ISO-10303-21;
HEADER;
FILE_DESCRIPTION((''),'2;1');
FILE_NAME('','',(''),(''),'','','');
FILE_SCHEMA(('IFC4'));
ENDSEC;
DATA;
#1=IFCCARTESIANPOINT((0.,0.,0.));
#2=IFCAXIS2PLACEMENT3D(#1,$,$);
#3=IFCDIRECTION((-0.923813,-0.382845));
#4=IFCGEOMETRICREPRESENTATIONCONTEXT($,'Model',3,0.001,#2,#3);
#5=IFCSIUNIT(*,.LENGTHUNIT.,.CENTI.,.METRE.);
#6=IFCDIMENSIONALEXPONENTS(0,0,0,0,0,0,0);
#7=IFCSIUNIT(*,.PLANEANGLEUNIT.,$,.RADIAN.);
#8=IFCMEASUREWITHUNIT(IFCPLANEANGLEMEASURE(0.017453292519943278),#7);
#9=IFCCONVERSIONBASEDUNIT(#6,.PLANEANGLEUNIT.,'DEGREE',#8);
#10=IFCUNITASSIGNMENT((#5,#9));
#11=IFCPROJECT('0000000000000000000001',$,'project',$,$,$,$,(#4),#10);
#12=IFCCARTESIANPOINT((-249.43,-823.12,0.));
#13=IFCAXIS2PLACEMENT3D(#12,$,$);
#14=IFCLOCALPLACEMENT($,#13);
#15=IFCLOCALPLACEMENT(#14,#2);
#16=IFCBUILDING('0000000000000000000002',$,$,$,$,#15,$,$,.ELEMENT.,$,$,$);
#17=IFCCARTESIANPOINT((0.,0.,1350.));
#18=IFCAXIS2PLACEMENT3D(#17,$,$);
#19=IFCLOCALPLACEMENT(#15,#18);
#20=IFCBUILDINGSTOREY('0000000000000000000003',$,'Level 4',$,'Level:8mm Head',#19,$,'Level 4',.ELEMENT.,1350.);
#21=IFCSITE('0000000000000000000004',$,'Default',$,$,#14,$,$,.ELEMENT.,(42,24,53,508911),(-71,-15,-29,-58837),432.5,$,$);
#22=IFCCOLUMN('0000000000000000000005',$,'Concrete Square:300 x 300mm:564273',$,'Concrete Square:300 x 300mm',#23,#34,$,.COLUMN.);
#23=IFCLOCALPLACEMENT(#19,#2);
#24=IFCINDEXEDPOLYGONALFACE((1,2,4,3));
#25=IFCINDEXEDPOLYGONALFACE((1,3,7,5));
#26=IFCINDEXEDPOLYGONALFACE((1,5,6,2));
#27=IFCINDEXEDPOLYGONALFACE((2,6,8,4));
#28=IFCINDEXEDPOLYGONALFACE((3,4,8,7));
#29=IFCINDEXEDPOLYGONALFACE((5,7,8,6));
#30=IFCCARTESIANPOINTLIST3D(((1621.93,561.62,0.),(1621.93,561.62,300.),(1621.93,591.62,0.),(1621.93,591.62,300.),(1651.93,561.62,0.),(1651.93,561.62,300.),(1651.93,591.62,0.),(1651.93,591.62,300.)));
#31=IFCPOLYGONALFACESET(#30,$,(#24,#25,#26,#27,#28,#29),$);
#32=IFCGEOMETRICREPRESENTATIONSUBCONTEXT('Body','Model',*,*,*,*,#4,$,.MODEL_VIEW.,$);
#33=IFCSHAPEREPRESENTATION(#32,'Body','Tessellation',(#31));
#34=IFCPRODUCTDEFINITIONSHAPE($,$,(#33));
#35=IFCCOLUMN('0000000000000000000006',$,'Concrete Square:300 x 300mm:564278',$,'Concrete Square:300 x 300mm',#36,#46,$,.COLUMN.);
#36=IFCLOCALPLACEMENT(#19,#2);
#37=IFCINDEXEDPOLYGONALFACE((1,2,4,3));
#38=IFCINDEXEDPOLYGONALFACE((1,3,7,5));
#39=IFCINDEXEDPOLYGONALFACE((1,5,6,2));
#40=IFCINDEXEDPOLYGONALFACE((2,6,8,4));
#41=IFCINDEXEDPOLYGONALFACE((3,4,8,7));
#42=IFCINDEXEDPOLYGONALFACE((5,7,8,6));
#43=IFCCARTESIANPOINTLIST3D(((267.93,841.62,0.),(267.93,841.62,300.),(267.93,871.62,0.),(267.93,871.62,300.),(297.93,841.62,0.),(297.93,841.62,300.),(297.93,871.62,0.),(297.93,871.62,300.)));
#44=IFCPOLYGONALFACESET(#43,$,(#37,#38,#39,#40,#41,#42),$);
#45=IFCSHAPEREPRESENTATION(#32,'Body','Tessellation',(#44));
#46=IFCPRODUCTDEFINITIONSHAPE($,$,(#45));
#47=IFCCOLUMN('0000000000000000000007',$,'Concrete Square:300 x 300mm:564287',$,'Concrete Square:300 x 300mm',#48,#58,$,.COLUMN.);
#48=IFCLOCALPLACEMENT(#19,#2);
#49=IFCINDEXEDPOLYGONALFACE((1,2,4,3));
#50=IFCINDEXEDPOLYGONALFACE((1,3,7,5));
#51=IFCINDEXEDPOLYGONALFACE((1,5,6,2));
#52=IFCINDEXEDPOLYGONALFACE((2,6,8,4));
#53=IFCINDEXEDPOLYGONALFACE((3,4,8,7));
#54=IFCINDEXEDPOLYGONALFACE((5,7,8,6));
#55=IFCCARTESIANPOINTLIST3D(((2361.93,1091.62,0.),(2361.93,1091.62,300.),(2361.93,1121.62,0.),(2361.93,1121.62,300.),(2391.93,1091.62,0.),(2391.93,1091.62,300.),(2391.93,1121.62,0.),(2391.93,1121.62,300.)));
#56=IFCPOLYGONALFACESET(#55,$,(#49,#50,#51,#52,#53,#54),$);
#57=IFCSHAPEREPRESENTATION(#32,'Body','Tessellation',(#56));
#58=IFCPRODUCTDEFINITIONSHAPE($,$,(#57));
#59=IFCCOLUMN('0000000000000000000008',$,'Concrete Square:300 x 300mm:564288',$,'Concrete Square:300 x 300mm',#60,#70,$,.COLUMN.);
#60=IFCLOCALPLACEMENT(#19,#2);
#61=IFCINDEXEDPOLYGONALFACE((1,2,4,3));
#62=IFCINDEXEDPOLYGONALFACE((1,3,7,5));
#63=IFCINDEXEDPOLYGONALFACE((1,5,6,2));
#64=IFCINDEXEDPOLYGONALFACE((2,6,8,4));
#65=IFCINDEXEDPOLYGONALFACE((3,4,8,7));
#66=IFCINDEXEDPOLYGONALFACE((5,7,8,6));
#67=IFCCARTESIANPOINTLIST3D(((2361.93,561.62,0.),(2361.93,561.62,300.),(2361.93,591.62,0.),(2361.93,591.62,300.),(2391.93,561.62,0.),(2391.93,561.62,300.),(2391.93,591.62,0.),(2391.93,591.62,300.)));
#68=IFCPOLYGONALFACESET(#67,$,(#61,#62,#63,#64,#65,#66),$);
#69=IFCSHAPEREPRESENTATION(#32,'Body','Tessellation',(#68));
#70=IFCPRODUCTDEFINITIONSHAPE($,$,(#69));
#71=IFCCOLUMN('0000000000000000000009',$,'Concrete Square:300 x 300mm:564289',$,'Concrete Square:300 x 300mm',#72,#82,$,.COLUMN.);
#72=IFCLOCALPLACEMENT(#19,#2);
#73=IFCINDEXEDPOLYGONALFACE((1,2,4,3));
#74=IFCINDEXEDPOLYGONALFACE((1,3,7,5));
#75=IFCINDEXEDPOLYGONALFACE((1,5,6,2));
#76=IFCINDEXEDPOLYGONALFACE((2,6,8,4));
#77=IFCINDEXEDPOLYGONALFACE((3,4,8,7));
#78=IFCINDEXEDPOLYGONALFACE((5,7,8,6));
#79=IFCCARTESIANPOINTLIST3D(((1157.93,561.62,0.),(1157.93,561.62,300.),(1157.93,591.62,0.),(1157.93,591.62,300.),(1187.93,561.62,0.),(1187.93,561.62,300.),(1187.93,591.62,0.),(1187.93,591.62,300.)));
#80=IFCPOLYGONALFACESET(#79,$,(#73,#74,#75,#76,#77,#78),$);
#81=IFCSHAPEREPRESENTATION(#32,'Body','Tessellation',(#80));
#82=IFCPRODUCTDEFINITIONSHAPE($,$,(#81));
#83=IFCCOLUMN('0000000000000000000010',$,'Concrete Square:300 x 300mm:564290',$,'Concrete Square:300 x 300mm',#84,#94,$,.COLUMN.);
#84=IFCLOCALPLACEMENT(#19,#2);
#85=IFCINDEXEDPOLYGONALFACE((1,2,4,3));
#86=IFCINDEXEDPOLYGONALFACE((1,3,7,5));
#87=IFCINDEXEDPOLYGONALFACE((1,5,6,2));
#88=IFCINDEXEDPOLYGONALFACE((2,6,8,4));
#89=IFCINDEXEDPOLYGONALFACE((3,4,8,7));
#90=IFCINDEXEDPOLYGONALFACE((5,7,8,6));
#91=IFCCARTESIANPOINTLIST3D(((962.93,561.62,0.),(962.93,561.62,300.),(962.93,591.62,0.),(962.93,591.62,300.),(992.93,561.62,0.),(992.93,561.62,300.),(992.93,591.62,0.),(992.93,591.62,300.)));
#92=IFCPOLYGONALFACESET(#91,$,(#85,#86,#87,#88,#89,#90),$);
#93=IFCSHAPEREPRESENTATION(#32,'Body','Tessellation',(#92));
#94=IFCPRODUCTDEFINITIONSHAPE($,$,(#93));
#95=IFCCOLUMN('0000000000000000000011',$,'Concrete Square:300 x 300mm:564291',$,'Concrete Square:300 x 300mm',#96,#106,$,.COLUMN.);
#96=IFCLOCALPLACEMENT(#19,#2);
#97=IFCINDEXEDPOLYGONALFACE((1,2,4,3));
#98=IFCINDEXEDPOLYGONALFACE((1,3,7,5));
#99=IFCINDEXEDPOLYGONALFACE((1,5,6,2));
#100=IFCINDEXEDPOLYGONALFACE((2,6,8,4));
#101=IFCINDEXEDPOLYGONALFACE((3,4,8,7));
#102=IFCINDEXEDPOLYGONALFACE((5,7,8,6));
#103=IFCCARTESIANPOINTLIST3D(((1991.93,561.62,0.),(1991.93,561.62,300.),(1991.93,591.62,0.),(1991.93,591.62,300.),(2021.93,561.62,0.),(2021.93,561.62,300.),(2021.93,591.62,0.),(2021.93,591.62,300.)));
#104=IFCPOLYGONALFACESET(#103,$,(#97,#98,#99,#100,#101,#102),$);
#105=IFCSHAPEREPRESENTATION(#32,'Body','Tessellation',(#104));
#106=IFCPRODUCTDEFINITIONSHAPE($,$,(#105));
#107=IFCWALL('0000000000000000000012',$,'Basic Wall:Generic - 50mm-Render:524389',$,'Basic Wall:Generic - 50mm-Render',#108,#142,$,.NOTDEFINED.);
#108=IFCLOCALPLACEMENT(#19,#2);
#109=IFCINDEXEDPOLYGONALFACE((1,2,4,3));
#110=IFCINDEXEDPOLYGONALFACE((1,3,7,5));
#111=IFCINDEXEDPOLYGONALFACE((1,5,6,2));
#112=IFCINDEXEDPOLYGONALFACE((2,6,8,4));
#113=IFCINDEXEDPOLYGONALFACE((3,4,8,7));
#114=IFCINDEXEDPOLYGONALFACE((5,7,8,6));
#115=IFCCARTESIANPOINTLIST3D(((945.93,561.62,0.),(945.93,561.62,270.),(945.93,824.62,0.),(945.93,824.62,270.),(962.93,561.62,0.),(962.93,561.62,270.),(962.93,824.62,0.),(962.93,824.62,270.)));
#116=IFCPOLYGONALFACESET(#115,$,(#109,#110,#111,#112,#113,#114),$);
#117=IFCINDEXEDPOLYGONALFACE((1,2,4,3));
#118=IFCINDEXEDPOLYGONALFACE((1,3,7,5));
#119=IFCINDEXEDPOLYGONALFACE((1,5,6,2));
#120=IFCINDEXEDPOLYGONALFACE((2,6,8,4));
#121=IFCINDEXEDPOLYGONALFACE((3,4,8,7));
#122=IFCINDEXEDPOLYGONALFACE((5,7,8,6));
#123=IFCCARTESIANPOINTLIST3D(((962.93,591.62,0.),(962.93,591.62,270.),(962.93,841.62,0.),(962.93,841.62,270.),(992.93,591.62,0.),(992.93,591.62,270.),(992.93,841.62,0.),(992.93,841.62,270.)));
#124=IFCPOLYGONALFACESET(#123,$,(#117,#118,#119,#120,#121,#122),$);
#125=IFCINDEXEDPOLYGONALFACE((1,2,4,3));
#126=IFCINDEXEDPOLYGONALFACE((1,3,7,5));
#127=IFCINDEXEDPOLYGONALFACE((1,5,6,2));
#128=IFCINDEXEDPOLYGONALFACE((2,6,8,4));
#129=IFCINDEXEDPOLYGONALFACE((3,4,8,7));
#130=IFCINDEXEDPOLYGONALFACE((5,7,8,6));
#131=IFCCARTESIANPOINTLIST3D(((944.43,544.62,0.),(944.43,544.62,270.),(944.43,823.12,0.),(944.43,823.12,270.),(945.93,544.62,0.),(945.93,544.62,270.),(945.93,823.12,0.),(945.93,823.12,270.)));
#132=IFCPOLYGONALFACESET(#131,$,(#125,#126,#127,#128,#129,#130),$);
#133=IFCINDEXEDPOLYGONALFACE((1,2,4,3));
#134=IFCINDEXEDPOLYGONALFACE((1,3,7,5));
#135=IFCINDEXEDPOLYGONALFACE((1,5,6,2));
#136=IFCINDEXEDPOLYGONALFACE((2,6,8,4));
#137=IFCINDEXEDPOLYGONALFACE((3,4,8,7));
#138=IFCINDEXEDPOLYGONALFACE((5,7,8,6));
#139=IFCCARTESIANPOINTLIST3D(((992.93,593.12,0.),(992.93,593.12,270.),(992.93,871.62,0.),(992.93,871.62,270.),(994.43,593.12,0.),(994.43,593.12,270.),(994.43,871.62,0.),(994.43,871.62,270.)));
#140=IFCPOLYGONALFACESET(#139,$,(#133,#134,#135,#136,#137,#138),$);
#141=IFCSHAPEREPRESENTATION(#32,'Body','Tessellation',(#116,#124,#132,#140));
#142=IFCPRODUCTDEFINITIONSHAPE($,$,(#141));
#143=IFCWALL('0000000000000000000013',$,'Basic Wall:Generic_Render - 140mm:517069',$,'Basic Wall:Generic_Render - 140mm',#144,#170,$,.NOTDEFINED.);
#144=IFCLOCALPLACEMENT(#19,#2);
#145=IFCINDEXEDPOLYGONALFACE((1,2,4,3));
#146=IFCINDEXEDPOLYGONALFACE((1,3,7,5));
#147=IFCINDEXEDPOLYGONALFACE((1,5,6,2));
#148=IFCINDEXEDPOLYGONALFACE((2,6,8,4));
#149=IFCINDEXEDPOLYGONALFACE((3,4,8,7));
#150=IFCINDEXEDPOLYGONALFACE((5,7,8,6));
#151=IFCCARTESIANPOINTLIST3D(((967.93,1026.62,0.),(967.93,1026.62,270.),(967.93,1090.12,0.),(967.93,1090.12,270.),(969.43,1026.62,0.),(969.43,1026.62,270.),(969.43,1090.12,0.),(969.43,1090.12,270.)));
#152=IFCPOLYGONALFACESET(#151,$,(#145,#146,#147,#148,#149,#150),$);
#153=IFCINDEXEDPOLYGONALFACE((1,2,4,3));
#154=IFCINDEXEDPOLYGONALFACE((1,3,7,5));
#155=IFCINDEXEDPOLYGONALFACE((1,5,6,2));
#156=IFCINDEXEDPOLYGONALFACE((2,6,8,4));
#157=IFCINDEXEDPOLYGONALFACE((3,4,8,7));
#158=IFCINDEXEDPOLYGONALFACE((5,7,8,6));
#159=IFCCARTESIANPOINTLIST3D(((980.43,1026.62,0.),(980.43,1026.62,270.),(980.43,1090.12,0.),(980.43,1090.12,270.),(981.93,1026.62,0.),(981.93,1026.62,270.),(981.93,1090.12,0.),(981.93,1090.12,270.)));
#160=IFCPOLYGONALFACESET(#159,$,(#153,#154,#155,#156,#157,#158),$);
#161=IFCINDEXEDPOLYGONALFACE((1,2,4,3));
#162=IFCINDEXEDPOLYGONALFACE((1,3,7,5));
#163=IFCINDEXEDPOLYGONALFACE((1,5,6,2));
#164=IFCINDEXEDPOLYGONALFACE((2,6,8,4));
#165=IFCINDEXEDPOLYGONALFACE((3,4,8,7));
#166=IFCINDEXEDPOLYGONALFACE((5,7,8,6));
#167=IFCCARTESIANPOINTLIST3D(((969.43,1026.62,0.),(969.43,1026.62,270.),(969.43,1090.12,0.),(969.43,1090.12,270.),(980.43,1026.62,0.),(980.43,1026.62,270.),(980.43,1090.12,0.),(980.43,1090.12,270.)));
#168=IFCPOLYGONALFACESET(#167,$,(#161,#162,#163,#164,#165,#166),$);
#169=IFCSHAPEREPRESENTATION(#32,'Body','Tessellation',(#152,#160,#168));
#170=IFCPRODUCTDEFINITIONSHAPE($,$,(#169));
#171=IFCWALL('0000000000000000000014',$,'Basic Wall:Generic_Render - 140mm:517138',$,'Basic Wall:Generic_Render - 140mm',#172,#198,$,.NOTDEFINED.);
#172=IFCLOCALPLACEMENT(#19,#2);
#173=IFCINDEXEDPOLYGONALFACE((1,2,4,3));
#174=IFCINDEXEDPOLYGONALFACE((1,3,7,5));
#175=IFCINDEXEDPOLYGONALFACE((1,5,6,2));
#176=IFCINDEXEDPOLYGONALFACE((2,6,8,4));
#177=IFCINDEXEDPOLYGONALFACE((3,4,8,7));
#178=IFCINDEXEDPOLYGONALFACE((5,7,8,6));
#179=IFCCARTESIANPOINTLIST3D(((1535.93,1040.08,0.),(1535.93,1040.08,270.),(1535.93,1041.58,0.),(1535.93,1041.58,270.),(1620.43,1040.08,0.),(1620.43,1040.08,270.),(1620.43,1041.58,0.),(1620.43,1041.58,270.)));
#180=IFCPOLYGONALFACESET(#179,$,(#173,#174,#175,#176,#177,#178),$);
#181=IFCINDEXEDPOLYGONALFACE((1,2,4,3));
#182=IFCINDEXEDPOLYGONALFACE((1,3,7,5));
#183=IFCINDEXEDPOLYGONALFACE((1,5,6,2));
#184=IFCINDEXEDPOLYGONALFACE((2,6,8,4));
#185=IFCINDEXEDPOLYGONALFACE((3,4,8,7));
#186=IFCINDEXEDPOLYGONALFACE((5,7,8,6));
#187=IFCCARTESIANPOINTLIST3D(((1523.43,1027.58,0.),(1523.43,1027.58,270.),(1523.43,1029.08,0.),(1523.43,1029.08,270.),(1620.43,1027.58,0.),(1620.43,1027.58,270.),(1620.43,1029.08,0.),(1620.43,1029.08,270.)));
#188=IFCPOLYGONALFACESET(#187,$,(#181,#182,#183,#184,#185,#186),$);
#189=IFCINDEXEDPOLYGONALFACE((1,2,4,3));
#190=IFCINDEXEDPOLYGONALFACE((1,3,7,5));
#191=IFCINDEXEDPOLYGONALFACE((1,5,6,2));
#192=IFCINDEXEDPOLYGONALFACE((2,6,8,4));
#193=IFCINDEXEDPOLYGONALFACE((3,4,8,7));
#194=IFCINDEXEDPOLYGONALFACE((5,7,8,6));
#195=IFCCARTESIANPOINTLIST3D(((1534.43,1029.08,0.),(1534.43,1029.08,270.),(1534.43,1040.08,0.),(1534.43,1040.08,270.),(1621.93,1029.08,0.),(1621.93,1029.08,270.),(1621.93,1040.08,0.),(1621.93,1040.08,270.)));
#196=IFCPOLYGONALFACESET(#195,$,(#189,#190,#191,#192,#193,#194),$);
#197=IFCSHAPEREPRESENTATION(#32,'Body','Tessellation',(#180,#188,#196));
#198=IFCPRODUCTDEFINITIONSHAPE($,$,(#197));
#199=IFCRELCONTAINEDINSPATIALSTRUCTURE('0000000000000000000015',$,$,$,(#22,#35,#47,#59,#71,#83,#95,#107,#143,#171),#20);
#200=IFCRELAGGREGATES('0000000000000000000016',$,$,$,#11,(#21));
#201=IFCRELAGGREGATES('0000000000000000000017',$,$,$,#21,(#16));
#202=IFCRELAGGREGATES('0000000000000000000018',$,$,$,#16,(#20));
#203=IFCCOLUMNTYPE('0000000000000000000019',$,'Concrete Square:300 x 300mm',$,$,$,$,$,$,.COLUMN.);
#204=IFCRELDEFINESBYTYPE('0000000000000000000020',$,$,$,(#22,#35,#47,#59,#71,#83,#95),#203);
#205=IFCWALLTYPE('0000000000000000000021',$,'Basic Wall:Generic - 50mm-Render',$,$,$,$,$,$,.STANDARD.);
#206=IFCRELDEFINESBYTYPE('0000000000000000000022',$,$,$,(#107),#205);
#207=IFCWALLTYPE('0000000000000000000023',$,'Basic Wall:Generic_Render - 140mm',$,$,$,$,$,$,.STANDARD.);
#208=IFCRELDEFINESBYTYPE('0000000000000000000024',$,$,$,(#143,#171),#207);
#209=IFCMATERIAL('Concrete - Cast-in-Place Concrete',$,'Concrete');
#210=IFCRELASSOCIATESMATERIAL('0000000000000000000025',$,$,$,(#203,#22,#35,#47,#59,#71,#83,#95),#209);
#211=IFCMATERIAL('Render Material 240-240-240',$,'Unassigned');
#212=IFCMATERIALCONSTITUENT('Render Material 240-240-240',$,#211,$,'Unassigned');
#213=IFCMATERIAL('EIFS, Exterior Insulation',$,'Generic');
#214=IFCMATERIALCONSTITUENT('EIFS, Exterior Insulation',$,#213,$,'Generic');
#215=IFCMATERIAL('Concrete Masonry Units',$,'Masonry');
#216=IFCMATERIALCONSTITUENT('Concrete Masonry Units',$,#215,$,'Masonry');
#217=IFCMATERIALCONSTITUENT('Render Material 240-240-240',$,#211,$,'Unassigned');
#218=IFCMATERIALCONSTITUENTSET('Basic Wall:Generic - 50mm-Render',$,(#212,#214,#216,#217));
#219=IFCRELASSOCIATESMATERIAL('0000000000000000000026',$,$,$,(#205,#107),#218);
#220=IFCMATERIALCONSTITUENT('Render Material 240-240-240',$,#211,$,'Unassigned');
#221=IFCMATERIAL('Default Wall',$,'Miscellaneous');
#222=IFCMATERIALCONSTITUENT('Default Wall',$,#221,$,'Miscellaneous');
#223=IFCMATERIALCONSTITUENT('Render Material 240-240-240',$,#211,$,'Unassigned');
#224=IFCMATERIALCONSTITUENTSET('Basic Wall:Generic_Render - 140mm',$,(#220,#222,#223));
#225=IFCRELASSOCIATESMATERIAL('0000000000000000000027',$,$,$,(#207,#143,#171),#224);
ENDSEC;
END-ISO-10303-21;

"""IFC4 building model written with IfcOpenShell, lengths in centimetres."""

from ifc_helpers import new_model, entity, si_unit, converted_unit, direction, frame, origin, place, context, subcontext, project, spatial, indexed_curve, outline, extrude, source, transform, mapped, material, constituent, constituent_set, type_object, type_shapes, element, save


model = new_model("IFC4")

# Units and contexts
model_context = context("Model", 3, precision=0.001, world=origin(), true_north=direction((-0.923813, -0.382845)))
body_context = subcontext(model_context, "Body", "Model", "MODEL_VIEW")
ifc_project = project(units=[si_unit("LENGTHUNIT", "METRE", prefix="CENTI"), converted_unit("PLANEANGLEUNIT", "DEGREE", entity("IfcPlaneAngleMeasure", 0.017453292519943278), si_unit("PLANEANGLEUNIT", "RADIAN"), dimensions=[0, 0, 0, 0, 0, 0, 0])], contexts=[model_context])

# Site, building, storey
site_placement = place(None, frame((-249.43, -823.12, 0.0)))
site = spatial("IfcSite", under=ifc_project, at=site_placement, Name="Default", CompositionType="ELEMENT", RefLatitude=(42, 24, 53, 508911), RefLongitude=(-71, -15, -29, -58837), RefElevation=432.5)
building_placement = place(site_placement, origin())
building = spatial("IfcBuilding", under=site, at=building_placement, CompositionType="ELEMENT")
storey_placement = place(building_placement, frame((0.0, 0.0, 1350.0)))
storey = spatial("IfcBuildingStorey", under=building, at=storey_placement, Name="Level 4", ObjectType="Level:8mm Head", LongName="Level 4", CompositionType="ELEMENT", Elevation=1350.0)

# Columns
ifc_material_1 = material(Name="Concrete - Cast-in-Place Concrete", Category="Concrete")
column_type = type_object("IfcColumnType", Name="Concrete Square:300 x 300mm", PredefinedType="COLUMN", material=ifc_material_1)
shared_shape = source(origin(), body_context, "Body", "SweptSolid", [
    extrude(outline(indexed_curve([(-15.0, -15.0), (15.0, -15.0), (15.0, 15.0), (-15.0, 15.0), (-15.0, -15.0)], self_intersect=False)), frame((0.0, 0.0, 1350.0), z_axis=(0.0, 0.0, 1.0), x_axis=(-1.0, 0.0, 0.0)), (0.0, 0.0, 1.0), 300.0),
])
type_shapes(column_type, [shared_shape])
for number, where, name in (
    (1, (1636.93, 576.62, -1350.0), "Concrete Square:300 x 300mm:564273"),
    (2, (282.93, 856.62, -1350.0), "Concrete Square:300 x 300mm:564278"),
    (3, (2376.93, 1106.62, -1350.0), "Concrete Square:300 x 300mm:564287"),
    (4, (2376.93, 576.62, -1350.0), "Concrete Square:300 x 300mm:564288"),
    (5, (1172.93, 576.62, -1350.0), "Concrete Square:300 x 300mm:564289"),
    (6, (977.93, 576.62, -1350.0), "Concrete Square:300 x 300mm:564290"),
    (7, (2006.93, 576.62, -1350.0), "Concrete Square:300 x 300mm:564291"),
):
    element("IfcColumn", number, at=place(storey_placement, frame(where)), inside=storey, type_object=column_type, material=ifc_material_1, Name=name, ObjectType="Concrete Square:300 x 300mm", PredefinedType="COLUMN", context=body_context, shape_type="MappedRepresentation", body=[
        mapped(shared_shape, transform((0.0, 0.0, 0.0), scale=1.0)),
    ])

# Walls
ifc_material_2 = material(Name="Render Material 240-240-240", Category="Unassigned")
ifc_material_3 = material(Name="Default Wall", Category="Miscellaneous")
ifc_constituent_1 = constituent(ifc_material_2, Name="Render Material 240-240-240", Category="Unassigned")
ifc_material_4 = material(Name="EIFS, Exterior Insulation", Category="Generic")
ifc_constituent_2 = constituent(ifc_material_4, Name="EIFS, Exterior Insulation", Category="Generic")
ifc_material_5 = material(Name="Concrete Masonry Units", Category="Masonry")
ifc_constituent_3 = constituent(ifc_material_5, Name="Concrete Masonry Units", Category="Masonry")
ifc_constituent_4 = constituent(ifc_material_2, Name="Render Material 240-240-240", Category="Unassigned")
ifc_constituent_set_1 = constituent_set(constituents=[ifc_constituent_1, ifc_constituent_2, ifc_constituent_3, ifc_constituent_4], Name="Basic Wall:Generic - 50mm-Render")
wall_type_1 = type_object("IfcWallType", Name="Basic Wall:Generic - 50mm-Render", PredefinedType="STANDARD", material=ifc_constituent_set_1)
wall_1_placement = place(storey_placement, frame((969.43, 823.12, 0.0), z_axis=(0.0, 0.0, 1.0), x_axis=(0.0, -1.0, 0.0)))
element("IfcWall", 8, at=wall_1_placement, inside=storey, type_object=wall_type_1, material=ifc_constituent_set_1, Name="Basic Wall:Generic - 50mm-Render:524389", ObjectType="Basic Wall:Generic - 50mm-Render", PredefinedType="NOTDEFINED", context=body_context, shape_type="SweptSolid", body=[
    extrude(outline(indexed_curve([(-131.5, -8.5), (131.5, -8.5), (131.5, 8.5), (-131.5, 8.5), (-131.5, -8.5)], self_intersect=False)), frame((130.0, -15.0, 0.0)), (0.0, 0.0, 1.0), 270.0),
    extrude(outline(indexed_curve([(-125.0, -15.0), (125.0, -15.0), (125.0, 15.0), (-125.0, 15.0), (-125.0, -15.0)], self_intersect=False)), frame((106.5, 8.5, 0.0)), (0.0, 0.0, 1.0), 270.0),
    extrude(outline(indexed_curve([(-0.75, -139.25), (0.75, -139.25), (0.75, 139.25), (-0.75, 139.25), (-0.75, -139.25)], self_intersect=False)), frame((139.25, -24.25, 0.0), z_axis=(0.0, 0.0, 1.0), x_axis=(0.0, 1.0, 0.0)), (0.0, 0.0, 1.0), 270.0),
    extrude(outline(indexed_curve([(-0.75, -139.25), (0.75, -139.25), (0.75, 139.25), (-0.75, 139.25), (-0.75, -139.25)], self_intersect=False)), frame((90.75, 24.25, 0.0), z_axis=(0.0, 0.0, 1.0), x_axis=(0.0, -1.0, 0.0)), (0.0, 0.0, 1.0), 270.0),
])
ifc_constituent_5 = constituent(ifc_material_2, Name="Render Material 240-240-240", Category="Unassigned")
ifc_constituent_6 = constituent(ifc_material_3, Name="Default Wall", Category="Miscellaneous")
ifc_constituent_7 = constituent(ifc_material_2, Name="Render Material 240-240-240", Category="Unassigned")
ifc_constituent_set_2 = constituent_set(constituents=[ifc_constituent_5, ifc_constituent_6, ifc_constituent_7], Name="Basic Wall:Generic_Render - 140mm")
wall_type_2 = type_object("IfcWallType", Name="Basic Wall:Generic_Render - 140mm", PredefinedType="STANDARD", material=ifc_constituent_set_2)
wall_2_placement = place(storey_placement, frame((974.93, 1090.12, 0.0), z_axis=(0.0, 0.0, 1.0), x_axis=(0.0, -1.0, 0.0)))
element("IfcWall", 9, at=wall_2_placement, inside=storey, type_object=wall_type_2, material=ifc_constituent_set_2, Name="Basic Wall:Generic_Render - 140mm:517069", ObjectType="Basic Wall:Generic_Render - 140mm", PredefinedType="NOTDEFINED", context=body_context, shape_type="SweptSolid", body=[
    extrude(outline(indexed_curve([(-0.75, -31.75), (0.75, -31.75), (0.75, 31.75), (-0.75, 31.75), (-0.75, -31.75)], self_intersect=False)), frame((31.75, -6.25, 0.0), z_axis=(0.0, 0.0, 1.0), x_axis=(0.0, 1.0, 0.0)), (0.0, 0.0, 1.0), 270.0),
    extrude(outline(indexed_curve([(-0.75, -31.75), (0.75, -31.75), (0.75, 31.75), (-0.75, 31.75), (-0.75, -31.75)], self_intersect=False)), frame((31.75, 6.25, 0.0), z_axis=(0.0, 0.0, 1.0), x_axis=(0.0, -1.0, 0.0)), (0.0, 0.0, 1.0), 270.0),
    extrude(outline(indexed_curve([(-31.75, -5.5), (31.75, -5.5), (31.75, 5.5), (-31.75, 5.5), (-31.75, -5.5)], self_intersect=False)), frame((31.75, 0.0, 0.0)), (0.0, 0.0, 1.0), 270.0),
])
wall_3_placement = place(storey_placement, frame((1535.93, 1034.58, 0.0)))
element("IfcWall", 10, at=wall_3_placement, inside=storey, type_object=wall_type_2, material=ifc_constituent_set_2, Name="Basic Wall:Generic_Render - 140mm:517138", ObjectType="Basic Wall:Generic_Render - 140mm", PredefinedType="NOTDEFINED", context=body_context, shape_type="SweptSolid", body=[
    extrude(outline(indexed_curve([(-0.75, -42.25), (0.75, -42.25), (0.75, 42.25), (-0.75, 42.25), (-0.75, -42.25)], self_intersect=False)), frame((42.25, 6.25, 0.0), z_axis=(0.0, 0.0, 1.0), x_axis=(0.0, -1.0, 0.0)), (0.0, 0.0, 1.0), 270.0),
    extrude(outline(indexed_curve([(-0.75, -48.5), (0.75, -48.5), (0.75, 48.5), (-0.75, 48.5), (-0.75, -48.5)], self_intersect=False)), frame((36.0, -6.25, 0.0), z_axis=(0.0, 0.0, 1.0), x_axis=(0.0, 1.0, 0.0)), (0.0, 0.0, 1.0), 270.0),
    extrude(outline(indexed_curve([(-43.75, -5.5), (43.75, -5.5), (43.75, 5.5), (-43.75, 5.5), (-43.75, -5.5)], self_intersect=False)), frame((42.25, 0.0, 0.0)), (0.0, 0.0, 1.0), 270.0),
])

save(model, "model.ifc")
